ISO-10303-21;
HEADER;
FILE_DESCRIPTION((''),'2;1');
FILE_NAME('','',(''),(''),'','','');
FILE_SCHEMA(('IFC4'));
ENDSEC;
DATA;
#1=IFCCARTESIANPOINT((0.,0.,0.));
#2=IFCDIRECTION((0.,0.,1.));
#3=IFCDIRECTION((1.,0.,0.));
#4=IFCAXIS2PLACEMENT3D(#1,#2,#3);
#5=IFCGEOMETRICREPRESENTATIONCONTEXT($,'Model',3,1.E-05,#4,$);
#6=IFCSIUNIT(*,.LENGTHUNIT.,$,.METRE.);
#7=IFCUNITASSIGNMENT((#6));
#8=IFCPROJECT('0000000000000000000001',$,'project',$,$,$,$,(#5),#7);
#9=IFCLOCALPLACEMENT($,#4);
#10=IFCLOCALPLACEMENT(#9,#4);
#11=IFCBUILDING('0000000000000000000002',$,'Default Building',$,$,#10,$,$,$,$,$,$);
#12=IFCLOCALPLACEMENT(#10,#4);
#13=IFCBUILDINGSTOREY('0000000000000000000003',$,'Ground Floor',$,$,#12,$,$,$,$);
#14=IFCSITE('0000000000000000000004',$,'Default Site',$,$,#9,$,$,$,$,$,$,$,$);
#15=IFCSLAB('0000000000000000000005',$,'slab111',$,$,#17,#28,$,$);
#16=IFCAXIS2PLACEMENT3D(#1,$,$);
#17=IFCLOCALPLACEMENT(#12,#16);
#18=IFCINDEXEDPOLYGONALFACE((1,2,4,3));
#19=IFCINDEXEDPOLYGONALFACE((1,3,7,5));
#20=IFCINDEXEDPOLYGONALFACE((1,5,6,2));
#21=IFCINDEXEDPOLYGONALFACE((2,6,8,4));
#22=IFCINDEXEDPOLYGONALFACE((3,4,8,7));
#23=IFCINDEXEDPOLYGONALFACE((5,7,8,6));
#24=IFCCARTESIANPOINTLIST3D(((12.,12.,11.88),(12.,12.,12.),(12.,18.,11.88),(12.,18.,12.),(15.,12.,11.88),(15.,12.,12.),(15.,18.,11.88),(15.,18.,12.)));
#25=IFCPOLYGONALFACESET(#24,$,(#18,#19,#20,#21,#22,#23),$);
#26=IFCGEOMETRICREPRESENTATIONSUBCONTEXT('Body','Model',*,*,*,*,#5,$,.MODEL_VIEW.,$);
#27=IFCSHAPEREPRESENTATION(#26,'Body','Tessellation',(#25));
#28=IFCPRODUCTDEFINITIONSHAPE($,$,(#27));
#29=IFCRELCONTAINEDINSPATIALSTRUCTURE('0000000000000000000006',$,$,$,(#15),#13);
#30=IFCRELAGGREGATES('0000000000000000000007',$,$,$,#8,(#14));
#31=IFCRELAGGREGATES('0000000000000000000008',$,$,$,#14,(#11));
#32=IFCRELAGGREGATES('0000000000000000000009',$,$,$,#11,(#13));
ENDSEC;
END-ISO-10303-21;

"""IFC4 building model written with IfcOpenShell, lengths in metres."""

from ifc_helpers import new_model, si_unit, frame, origin_with_axes, place, context, subcontext, project, spatial, indexed_curve, outline, extrude, element, save


model = new_model("IFC4")

# Units and contexts
model_context = context("Model", 3, precision=1e-05, world=origin_with_axes())
body_context = subcontext(model_context, "Body", "Model", "MODEL_VIEW")
ifc_project = project(units=[si_unit("LENGTHUNIT", "METRE")], contexts=[model_context])

# Site, building, storey
site_placement = place(None, origin_with_axes())
site = spatial("IfcSite", under=ifc_project, at=site_placement, Name="Default Site")
building_placement = place(site_placement, origin_with_axes())
building = spatial("IfcBuilding", under=site, at=building_placement, Name="Default Building")
storey_placement = place(building_placement, origin_with_axes())
storey = spatial("IfcBuildingStorey", under=building, at=storey_placement, Name="Ground Floor")

# Slab
for number, where, z_axis, x_axis, name in (
    (1, (12.0, 12.0, 11.88), (0.0, 0.0, 1.0), (1.0, 0.0, 0.0), "slab111"),
):
    element("IfcSlab", number, at=place(storey_placement, frame(where, z_axis=z_axis, x_axis=x_axis)), inside=storey, Name=name, context=body_context, shape_type="SweptSolid", body=[
        extrude(outline(indexed_curve([(0.0, 0.0), (0.0, 6.0), (3.0, 6.0), (3.0, 0.0), (0.0, 0.0)], self_intersect=False)), origin_with_axes(), (0.0, 0.0, 1.0), 0.12),
    ])

save(model, "model.ifc")
